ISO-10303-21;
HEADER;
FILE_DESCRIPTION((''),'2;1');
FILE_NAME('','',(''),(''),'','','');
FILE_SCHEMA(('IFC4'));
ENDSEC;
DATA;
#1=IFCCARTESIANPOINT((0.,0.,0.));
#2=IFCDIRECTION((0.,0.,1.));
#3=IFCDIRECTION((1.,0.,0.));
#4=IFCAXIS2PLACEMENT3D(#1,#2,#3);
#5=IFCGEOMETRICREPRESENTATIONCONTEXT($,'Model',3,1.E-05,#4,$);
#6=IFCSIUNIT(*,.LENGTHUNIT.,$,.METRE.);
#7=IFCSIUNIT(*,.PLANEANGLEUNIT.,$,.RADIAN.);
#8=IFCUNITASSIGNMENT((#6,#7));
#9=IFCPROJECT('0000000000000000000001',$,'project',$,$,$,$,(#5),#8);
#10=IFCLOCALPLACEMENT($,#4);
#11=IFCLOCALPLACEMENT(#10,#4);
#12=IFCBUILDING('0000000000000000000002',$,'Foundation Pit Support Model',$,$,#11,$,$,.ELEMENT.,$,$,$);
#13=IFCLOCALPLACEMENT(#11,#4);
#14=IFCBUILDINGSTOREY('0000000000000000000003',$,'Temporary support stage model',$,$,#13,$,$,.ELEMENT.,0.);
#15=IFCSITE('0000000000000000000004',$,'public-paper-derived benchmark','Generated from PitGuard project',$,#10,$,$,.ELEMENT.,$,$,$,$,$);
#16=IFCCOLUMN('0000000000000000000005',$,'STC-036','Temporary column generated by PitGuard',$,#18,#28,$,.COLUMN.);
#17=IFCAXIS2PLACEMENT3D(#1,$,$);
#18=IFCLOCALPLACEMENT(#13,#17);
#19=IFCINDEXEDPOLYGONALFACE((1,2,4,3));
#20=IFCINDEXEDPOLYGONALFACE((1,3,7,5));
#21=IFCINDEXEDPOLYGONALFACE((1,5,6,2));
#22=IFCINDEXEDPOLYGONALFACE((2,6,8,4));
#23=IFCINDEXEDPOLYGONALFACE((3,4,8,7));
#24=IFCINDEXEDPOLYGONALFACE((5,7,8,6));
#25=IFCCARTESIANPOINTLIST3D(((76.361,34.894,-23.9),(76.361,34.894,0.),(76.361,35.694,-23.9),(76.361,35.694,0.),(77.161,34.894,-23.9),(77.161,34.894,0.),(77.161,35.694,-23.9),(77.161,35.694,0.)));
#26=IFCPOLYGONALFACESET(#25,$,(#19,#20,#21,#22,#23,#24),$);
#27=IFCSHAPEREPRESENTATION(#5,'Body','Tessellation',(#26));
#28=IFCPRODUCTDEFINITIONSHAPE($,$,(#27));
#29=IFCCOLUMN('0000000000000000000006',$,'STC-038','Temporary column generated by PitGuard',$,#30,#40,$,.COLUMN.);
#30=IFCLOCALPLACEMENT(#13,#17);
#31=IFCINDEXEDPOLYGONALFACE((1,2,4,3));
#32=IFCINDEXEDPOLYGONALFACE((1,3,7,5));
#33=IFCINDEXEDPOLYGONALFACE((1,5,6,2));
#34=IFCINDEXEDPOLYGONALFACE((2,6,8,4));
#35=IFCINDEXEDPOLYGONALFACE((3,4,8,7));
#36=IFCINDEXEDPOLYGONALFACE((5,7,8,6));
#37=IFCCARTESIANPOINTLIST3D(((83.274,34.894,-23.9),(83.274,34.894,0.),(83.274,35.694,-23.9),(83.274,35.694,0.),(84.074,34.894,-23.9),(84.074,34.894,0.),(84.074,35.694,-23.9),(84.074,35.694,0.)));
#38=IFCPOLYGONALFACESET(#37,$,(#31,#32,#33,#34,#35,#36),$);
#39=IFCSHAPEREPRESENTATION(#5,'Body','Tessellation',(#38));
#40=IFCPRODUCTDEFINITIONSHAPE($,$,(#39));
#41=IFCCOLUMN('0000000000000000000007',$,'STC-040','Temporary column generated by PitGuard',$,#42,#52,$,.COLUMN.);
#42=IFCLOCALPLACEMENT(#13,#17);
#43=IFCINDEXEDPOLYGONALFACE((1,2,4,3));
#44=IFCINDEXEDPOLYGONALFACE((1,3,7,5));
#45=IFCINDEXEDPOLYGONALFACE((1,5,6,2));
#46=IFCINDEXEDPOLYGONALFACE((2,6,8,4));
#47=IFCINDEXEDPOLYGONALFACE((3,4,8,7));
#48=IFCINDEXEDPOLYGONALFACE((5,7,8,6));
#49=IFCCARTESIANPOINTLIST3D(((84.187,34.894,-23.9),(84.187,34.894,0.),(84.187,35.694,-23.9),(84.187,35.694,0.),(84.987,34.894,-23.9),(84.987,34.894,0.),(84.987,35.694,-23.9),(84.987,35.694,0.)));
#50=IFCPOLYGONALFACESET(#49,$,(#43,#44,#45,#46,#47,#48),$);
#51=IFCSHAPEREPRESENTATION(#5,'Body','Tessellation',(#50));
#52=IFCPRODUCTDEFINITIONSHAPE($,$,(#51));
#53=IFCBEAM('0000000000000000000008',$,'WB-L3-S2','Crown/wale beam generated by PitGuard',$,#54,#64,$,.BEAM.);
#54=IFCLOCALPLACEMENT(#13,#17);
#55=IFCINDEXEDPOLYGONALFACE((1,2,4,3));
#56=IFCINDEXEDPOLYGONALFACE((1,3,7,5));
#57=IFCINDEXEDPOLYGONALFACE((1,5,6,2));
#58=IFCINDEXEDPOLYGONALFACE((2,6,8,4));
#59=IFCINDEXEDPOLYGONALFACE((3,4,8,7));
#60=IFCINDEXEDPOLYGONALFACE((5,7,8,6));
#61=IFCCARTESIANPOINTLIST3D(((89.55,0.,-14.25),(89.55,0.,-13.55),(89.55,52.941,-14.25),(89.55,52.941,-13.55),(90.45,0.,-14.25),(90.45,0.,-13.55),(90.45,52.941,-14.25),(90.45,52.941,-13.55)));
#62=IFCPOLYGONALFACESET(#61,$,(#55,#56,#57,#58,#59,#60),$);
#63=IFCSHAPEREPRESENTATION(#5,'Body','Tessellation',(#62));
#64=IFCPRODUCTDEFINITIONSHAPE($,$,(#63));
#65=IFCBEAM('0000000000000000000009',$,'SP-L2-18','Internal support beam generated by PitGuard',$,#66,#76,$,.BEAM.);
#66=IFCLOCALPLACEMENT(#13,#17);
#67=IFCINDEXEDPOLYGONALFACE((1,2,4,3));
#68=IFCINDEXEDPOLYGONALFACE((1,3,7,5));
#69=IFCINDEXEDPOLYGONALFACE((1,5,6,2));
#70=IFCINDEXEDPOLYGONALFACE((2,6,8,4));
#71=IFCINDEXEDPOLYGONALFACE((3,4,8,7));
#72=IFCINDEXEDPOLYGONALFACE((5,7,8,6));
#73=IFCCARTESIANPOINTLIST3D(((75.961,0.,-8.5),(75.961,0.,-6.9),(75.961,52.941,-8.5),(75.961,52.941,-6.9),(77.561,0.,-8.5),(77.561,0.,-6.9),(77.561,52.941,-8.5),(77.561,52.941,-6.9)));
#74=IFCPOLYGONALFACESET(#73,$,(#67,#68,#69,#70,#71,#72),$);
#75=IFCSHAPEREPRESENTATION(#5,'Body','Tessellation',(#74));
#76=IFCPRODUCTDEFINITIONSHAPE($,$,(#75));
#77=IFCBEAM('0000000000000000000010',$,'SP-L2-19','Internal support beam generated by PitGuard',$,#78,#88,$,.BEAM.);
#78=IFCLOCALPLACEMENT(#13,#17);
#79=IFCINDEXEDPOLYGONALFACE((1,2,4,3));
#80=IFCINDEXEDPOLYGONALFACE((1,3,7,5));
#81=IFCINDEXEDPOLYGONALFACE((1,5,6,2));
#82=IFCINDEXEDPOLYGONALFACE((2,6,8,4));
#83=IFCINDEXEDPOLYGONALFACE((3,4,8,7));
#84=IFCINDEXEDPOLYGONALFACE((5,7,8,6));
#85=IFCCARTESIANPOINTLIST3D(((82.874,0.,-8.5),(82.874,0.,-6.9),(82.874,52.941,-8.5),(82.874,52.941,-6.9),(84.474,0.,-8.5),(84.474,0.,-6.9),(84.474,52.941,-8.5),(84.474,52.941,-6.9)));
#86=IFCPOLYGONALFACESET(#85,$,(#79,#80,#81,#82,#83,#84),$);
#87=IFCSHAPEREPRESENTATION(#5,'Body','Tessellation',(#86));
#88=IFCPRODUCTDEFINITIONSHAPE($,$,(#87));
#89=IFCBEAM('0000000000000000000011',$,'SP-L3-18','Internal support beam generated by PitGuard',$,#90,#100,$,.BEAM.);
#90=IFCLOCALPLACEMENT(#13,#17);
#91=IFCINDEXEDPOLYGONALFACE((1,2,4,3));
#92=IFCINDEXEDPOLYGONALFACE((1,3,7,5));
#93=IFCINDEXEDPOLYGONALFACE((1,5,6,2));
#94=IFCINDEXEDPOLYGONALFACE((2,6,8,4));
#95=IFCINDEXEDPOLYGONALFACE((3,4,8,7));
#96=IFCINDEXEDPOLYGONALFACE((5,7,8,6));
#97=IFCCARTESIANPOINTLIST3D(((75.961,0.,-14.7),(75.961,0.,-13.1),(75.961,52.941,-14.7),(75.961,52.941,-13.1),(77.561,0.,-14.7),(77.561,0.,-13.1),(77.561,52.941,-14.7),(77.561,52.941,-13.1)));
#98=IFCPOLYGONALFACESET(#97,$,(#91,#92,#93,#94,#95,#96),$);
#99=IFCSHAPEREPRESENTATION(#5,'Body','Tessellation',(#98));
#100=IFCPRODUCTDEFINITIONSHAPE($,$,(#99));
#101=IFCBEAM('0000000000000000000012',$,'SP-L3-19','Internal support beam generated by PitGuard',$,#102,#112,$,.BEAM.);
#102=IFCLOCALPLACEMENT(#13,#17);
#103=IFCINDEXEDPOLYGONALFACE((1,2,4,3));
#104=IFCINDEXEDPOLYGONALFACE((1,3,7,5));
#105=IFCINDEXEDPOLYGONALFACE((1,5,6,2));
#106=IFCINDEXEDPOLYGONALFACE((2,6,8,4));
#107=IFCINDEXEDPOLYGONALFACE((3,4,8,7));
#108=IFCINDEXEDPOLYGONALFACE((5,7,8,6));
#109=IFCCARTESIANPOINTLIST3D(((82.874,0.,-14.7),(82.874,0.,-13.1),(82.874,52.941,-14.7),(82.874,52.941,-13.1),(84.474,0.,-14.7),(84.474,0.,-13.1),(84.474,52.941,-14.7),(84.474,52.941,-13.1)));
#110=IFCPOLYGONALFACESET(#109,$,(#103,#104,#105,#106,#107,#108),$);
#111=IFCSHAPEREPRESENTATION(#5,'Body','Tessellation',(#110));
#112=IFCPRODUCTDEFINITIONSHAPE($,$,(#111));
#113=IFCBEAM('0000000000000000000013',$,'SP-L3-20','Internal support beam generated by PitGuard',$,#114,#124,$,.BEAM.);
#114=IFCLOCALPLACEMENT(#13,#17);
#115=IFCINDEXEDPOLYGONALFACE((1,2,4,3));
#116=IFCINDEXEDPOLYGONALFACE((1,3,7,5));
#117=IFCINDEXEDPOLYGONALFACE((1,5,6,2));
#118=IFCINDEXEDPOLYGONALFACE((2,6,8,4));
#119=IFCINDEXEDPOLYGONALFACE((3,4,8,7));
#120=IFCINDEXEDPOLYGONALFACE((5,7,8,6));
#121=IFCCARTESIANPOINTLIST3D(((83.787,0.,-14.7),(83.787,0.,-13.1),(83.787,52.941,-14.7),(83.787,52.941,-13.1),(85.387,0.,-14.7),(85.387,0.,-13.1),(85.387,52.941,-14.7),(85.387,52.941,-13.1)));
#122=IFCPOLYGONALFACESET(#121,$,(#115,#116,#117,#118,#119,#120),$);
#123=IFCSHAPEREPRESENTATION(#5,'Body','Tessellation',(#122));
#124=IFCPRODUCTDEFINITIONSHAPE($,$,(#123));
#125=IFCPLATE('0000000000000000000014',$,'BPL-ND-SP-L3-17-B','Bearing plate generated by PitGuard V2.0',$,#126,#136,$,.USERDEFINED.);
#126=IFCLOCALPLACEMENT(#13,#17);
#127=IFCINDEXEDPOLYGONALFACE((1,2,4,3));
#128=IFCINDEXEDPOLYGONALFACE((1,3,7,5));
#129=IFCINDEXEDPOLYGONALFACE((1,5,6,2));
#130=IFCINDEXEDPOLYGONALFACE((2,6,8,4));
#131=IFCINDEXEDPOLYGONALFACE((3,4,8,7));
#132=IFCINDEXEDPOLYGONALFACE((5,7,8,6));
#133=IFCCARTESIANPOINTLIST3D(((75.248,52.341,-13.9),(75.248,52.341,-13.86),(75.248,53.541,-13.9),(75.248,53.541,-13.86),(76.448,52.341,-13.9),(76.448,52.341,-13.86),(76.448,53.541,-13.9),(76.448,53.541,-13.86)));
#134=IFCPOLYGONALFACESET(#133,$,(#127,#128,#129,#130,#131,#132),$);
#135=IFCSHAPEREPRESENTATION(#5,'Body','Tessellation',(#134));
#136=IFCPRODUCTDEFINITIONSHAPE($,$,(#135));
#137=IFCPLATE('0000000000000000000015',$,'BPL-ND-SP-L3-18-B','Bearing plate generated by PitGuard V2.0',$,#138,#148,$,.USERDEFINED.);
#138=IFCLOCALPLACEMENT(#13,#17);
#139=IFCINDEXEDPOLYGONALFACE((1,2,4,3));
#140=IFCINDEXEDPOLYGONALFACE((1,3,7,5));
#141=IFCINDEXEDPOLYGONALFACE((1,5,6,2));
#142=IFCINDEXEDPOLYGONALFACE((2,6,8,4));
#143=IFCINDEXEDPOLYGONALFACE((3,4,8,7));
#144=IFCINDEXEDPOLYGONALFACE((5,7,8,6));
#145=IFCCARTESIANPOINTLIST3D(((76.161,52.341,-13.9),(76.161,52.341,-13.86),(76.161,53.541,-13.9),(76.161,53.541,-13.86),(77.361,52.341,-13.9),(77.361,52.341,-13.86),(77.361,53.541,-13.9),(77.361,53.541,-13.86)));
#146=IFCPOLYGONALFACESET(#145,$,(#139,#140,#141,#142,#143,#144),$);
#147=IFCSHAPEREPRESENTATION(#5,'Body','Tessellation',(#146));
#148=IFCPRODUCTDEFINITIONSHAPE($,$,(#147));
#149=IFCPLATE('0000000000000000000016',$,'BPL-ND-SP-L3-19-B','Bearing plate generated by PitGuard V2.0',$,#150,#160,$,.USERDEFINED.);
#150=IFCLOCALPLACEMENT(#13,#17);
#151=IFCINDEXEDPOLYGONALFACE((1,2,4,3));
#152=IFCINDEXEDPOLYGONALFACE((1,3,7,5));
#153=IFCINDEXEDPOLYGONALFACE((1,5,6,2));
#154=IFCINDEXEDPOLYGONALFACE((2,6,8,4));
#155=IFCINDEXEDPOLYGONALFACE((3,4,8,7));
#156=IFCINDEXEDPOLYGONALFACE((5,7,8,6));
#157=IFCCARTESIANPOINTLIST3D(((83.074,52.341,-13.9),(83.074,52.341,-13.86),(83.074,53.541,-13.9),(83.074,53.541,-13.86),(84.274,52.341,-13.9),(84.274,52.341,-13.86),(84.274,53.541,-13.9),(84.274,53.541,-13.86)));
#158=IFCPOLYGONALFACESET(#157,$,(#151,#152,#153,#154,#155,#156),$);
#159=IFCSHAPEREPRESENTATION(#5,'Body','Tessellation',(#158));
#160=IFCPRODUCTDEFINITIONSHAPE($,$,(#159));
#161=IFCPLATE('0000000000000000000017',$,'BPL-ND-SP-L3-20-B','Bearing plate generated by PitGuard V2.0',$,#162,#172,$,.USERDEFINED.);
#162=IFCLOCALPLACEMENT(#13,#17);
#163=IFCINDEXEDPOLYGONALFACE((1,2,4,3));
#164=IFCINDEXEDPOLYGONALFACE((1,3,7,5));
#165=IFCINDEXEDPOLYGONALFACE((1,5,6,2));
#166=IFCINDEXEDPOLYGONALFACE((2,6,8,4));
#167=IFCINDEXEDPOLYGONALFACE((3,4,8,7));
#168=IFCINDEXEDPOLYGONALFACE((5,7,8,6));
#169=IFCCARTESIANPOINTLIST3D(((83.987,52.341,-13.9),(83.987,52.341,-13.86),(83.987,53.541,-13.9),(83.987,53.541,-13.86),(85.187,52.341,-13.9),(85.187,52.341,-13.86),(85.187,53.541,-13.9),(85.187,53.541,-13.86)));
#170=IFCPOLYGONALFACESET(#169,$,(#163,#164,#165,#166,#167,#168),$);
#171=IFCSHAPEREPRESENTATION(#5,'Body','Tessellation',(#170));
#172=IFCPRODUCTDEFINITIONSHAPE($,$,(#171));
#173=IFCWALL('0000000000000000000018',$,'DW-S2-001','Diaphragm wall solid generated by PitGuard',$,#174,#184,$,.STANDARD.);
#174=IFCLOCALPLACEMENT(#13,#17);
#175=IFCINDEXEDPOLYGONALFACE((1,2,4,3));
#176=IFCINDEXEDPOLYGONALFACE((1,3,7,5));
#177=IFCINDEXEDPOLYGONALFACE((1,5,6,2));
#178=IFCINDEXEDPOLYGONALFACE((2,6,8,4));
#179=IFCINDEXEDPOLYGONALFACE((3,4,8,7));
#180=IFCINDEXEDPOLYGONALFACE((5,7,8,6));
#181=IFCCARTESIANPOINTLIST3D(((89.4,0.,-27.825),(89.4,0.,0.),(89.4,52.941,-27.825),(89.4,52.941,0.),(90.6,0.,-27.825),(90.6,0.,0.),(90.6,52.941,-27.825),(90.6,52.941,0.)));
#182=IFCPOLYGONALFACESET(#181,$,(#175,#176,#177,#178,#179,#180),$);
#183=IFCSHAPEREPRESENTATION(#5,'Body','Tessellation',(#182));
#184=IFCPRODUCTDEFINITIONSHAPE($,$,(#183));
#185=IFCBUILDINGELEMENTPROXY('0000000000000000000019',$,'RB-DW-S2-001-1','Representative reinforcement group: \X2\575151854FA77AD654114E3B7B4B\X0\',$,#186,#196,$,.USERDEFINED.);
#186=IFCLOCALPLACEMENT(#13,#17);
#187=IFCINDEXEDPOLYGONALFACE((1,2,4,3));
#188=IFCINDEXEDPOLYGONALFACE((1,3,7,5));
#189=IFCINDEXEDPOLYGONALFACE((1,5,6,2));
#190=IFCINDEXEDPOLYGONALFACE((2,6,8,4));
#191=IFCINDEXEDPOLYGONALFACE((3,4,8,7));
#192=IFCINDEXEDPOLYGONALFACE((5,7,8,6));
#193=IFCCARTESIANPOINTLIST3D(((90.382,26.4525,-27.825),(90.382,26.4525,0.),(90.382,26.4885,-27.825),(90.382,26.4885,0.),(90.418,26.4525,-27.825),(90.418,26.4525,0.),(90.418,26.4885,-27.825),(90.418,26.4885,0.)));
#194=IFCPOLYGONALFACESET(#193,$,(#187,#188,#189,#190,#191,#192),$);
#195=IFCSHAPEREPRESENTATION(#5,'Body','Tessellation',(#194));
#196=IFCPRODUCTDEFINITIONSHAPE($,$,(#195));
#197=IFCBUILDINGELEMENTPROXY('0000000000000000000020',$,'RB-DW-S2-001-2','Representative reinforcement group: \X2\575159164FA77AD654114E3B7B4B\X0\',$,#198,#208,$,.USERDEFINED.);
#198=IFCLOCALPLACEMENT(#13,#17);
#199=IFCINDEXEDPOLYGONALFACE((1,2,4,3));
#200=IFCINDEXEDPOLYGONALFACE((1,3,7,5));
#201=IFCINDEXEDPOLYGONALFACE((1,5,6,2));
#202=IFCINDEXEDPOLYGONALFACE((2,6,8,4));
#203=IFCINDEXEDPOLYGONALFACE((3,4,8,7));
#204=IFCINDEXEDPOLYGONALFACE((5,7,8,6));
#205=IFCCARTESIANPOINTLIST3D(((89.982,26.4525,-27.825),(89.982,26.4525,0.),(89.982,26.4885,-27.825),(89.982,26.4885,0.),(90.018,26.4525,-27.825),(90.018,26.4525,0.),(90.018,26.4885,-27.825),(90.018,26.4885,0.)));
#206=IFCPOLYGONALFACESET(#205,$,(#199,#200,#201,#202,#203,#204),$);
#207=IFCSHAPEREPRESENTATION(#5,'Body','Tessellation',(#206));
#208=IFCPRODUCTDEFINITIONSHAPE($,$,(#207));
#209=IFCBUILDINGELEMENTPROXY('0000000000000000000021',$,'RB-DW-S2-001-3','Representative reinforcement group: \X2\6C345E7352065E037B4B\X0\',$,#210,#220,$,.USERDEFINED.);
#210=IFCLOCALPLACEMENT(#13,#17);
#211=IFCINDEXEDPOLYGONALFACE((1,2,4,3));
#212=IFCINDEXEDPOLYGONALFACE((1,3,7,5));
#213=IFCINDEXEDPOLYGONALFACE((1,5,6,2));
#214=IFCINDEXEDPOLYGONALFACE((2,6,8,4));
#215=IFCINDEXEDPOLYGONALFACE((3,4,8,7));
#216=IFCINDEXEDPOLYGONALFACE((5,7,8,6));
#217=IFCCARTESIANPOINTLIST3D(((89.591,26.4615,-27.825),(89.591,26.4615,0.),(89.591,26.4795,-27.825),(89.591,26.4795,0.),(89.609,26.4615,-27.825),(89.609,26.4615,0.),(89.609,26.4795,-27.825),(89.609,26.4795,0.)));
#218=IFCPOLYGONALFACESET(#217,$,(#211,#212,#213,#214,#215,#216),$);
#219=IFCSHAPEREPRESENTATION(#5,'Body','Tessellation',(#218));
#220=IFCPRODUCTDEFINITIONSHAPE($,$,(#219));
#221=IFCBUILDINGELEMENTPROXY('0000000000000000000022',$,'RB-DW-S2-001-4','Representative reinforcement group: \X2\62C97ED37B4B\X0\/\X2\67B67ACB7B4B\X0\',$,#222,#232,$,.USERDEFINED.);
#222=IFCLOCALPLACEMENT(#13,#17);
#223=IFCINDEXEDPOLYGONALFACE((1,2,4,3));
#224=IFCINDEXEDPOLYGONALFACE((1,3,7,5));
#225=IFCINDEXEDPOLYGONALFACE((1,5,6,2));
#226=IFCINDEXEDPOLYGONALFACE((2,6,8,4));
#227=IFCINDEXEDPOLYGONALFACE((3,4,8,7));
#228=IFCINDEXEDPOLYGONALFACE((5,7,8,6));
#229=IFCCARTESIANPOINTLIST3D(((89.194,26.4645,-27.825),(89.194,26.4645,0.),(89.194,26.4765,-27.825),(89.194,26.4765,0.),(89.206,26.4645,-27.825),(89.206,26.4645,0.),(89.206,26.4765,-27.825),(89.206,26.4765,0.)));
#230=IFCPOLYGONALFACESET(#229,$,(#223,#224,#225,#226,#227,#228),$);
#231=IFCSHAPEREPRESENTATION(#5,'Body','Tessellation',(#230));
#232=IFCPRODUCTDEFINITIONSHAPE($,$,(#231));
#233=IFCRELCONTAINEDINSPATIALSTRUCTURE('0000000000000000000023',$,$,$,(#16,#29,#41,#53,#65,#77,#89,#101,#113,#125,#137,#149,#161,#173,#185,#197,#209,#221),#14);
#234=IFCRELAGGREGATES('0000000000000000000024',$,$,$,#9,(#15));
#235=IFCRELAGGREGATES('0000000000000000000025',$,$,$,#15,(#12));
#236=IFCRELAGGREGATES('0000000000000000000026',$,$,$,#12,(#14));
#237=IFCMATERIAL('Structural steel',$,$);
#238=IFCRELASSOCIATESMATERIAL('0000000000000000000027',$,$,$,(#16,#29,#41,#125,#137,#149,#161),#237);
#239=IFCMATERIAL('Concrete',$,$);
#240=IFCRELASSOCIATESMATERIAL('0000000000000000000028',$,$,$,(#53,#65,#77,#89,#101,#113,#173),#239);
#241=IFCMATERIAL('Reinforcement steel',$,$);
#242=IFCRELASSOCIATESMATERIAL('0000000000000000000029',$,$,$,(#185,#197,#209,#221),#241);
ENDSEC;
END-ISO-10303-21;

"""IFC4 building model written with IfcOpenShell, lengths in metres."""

from ifc_helpers import new_model, si_unit, frame, origin_with_axes, origin_2d, place, context, project, spatial, rectangle, extrude, material, element, save


model = new_model("IFC4")

# Units and contexts
model_context = context("Model", 3, precision=1e-05, world=origin_with_axes())
ifc_project = project(units=[si_unit("LENGTHUNIT", "METRE"), si_unit("PLANEANGLEUNIT", "RADIAN")], contexts=[model_context])

# Site, building, storey
site_placement = place(None, origin_with_axes())
site = spatial("IfcSite", under=ifc_project, at=site_placement, Name="public-paper-derived benchmark", Description="Generated from PitGuard project", CompositionType="ELEMENT")
building_placement = place(site_placement, origin_with_axes())
building = spatial("IfcBuilding", under=site, at=building_placement, Name="Foundation Pit Support Model", CompositionType="ELEMENT")
storey_placement = place(building_placement, origin_with_axes())
storey = spatial("IfcBuildingStorey", under=building, at=storey_placement, Name="Temporary support stage model", CompositionType="ELEMENT", Elevation=0.0)

# Columns
ifc_material_1 = material(Name="Structural steel")
for number, where, z_axis, x_axis, name in (
    (1, (76.761, 35.294, -23.9), (0.0, 0.0, 1.0), (1.0, 0.0, 0.0), "STC-036"),
    (2, (83.674, 35.294, -23.9), (0.0, 0.0, 1.0), (1.0, 0.0, 0.0), "STC-038"),
    (3, (84.587, 35.294, -23.9), (0.0, 0.0, 1.0), (1.0, 0.0, 0.0), "STC-040"),
):
    element("IfcColumn", number, at=place(storey_placement, frame(where, z_axis=z_axis, x_axis=x_axis)), inside=storey, material=ifc_material_1, Name=name, Description="Temporary column generated by PitGuard", PredefinedType="COLUMN", context=model_context, shape_type="SweptSolid", body=[
        extrude(rectangle(XDim=0.8, YDim=0.8, at=origin_2d()), origin_with_axes(), (0.0, 0.0, 1.0), 23.9),
    ])

# Beams
ifc_material_2 = material(Name="Concrete")
beam_placement = place(storey_placement, frame((90.0, 26.4705, -14.25), z_axis=(0.0, 0.0, 1.0), x_axis=(0.0, 1.0, 0.0)))
element("IfcBeam", 4, at=beam_placement, inside=storey, material=ifc_material_2, Name="WB-L3-S2", Description="Crown/wale beam generated by PitGuard", PredefinedType="BEAM", context=model_context, shape_type="SweptSolid", body=[
    extrude(rectangle(XDim=52.941, YDim=0.9, at=origin_2d()), origin_with_axes(), (0.0, 0.0, 1.0), 0.7),
])
for number, where, z_axis, x_axis, name in (
    (5, (76.761, 26.4705, -8.5), (0.0, 0.0, 1.0), (0.0, 1.0, 0.0), "SP-L2-18"),
    (6, (83.674, 26.4705, -8.5), (0.0, 0.0, 1.0), (0.0, 1.0, 0.0), "SP-L2-19"),
    (7, (76.761, 26.4705, -14.7), (0.0, 0.0, 1.0), (0.0, 1.0, 0.0), "SP-L3-18"),
    (8, (83.674, 26.4705, -14.7), (0.0, 0.0, 1.0), (0.0, 1.0, 0.0), "SP-L3-19"),
    (9, (84.587, 26.4705, -14.7), (0.0, 0.0, 1.0), (0.0, 1.0, 0.0), "SP-L3-20"),
):
    element("IfcBeam", number, at=place(storey_placement, frame(where, z_axis=z_axis, x_axis=x_axis)), inside=storey, material=ifc_material_2, Name=name, Description="Internal support beam generated by PitGuard", PredefinedType="BEAM", context=model_context, shape_type="SweptSolid", body=[
        extrude(rectangle(XDim=52.941, YDim=1.6, at=origin_2d()), origin_with_axes(), (0.0, 0.0, 1.0), 1.6),
    ])

# Plates
for number, where, z_axis, x_axis, name in (
    (10, (75.848, 52.941, -13.9), (0.0, 0.0, 1.0), (1.0, 0.0, 0.0), "BPL-ND-SP-L3-17-B"),
    (11, (76.761, 52.941, -13.9), (0.0, 0.0, 1.0), (1.0, 0.0, 0.0), "BPL-ND-SP-L3-18-B"),
    (12, (83.674, 52.941, -13.9), (0.0, 0.0, 1.0), (1.0, 0.0, 0.0), "BPL-ND-SP-L3-19-B"),
    (13, (84.587, 52.941, -13.9), (0.0, 0.0, 1.0), (1.0, 0.0, 0.0), "BPL-ND-SP-L3-20-B"),
):
    element("IfcPlate", number, at=place(storey_placement, frame(where, z_axis=z_axis, x_axis=x_axis)), inside=storey, material=ifc_material_1, Name=name, Description="Bearing plate generated by PitGuard V2.0", PredefinedType="USERDEFINED", context=model_context, shape_type="SweptSolid", body=[
        extrude(rectangle(XDim=1.2, YDim=1.2, at=origin_2d()), origin_with_axes(), (0.0, 0.0, 1.0), 0.04),
    ])

# Wall
wall_placement = place(storey_placement, frame((90.0, 26.4705, -27.825), z_axis=(0.0, 0.0, 1.0), x_axis=(0.0, 1.0, 0.0)))
element("IfcWall", 14, at=wall_placement, inside=storey, material=ifc_material_2, Name="DW-S2-001", Description="Diaphragm wall solid generated by PitGuard", PredefinedType="STANDARD", context=model_context, shape_type="SweptSolid", body=[
    extrude(rectangle(XDim=52.941, YDim=1.2, at=origin_2d()), origin_with_axes(), (0.0, 0.0, 1.0), 27.825),
])

# Building element proxies
ifc_material_3 = material(Name="Reinforcement steel")
for number, where, z_axis, x_axis, name, description in (
    (15, (90.4, 26.4705, -27.825), (0.0, 0.0, 1.0), (1.0, 0.0, 0.0), "RB-DW-S2-001-1", "Representative reinforcement group: 坑内侧竖向主筋"),
    (16, (90.0, 26.4705, -27.825), (0.0, 0.0, 1.0), (1.0, 0.0, 0.0), "RB-DW-S2-001-2", "Representative reinforcement group: 坑外侧竖向主筋"),
):
    element("IfcBuildingElementProxy", number, at=place(storey_placement, frame(where, z_axis=z_axis, x_axis=x_axis)), inside=storey, material=ifc_material_3, Name=name, Description=description, PredefinedType="USERDEFINED", context=model_context, shape_type="SweptSolid", body=[
        extrude(rectangle(XDim=0.036, YDim=0.036, at=origin_2d()), origin_with_axes(), (0.0, 0.0, 1.0), 27.825),
    ])
proxy_1_placement = place(storey_placement, frame((89.6, 26.4705, -27.825), z_axis=(0.0, 0.0, 1.0), x_axis=(1.0, 0.0, 0.0)))
element("IfcBuildingElementProxy", 17, at=proxy_1_placement, inside=storey, material=ifc_material_3, Name="RB-DW-S2-001-3", Description="Representative reinforcement group: 水平分布筋", PredefinedType="USERDEFINED", context=model_context, shape_type="SweptSolid", body=[
    extrude(rectangle(XDim=0.018, YDim=0.018, at=origin_2d()), origin_with_axes(), (0.0, 0.0, 1.0), 27.825),
])
proxy_2_placement = place(storey_placement, frame((89.2, 26.4705, -27.825), z_axis=(0.0, 0.0, 1.0), x_axis=(1.0, 0.0, 0.0)))
element("IfcBuildingElementProxy", 18, at=proxy_2_placement, inside=storey, material=ifc_material_3, Name="RB-DW-S2-001-4", Description="Representative reinforcement group: 拉结筋/架立筋", PredefinedType="USERDEFINED", context=model_context, shape_type="SweptSolid", body=[
    extrude(rectangle(XDim=0.012, YDim=0.012, at=origin_2d()), origin_with_axes(), (0.0, 0.0, 1.0), 27.825),
])

save(model, "model.ifc")
